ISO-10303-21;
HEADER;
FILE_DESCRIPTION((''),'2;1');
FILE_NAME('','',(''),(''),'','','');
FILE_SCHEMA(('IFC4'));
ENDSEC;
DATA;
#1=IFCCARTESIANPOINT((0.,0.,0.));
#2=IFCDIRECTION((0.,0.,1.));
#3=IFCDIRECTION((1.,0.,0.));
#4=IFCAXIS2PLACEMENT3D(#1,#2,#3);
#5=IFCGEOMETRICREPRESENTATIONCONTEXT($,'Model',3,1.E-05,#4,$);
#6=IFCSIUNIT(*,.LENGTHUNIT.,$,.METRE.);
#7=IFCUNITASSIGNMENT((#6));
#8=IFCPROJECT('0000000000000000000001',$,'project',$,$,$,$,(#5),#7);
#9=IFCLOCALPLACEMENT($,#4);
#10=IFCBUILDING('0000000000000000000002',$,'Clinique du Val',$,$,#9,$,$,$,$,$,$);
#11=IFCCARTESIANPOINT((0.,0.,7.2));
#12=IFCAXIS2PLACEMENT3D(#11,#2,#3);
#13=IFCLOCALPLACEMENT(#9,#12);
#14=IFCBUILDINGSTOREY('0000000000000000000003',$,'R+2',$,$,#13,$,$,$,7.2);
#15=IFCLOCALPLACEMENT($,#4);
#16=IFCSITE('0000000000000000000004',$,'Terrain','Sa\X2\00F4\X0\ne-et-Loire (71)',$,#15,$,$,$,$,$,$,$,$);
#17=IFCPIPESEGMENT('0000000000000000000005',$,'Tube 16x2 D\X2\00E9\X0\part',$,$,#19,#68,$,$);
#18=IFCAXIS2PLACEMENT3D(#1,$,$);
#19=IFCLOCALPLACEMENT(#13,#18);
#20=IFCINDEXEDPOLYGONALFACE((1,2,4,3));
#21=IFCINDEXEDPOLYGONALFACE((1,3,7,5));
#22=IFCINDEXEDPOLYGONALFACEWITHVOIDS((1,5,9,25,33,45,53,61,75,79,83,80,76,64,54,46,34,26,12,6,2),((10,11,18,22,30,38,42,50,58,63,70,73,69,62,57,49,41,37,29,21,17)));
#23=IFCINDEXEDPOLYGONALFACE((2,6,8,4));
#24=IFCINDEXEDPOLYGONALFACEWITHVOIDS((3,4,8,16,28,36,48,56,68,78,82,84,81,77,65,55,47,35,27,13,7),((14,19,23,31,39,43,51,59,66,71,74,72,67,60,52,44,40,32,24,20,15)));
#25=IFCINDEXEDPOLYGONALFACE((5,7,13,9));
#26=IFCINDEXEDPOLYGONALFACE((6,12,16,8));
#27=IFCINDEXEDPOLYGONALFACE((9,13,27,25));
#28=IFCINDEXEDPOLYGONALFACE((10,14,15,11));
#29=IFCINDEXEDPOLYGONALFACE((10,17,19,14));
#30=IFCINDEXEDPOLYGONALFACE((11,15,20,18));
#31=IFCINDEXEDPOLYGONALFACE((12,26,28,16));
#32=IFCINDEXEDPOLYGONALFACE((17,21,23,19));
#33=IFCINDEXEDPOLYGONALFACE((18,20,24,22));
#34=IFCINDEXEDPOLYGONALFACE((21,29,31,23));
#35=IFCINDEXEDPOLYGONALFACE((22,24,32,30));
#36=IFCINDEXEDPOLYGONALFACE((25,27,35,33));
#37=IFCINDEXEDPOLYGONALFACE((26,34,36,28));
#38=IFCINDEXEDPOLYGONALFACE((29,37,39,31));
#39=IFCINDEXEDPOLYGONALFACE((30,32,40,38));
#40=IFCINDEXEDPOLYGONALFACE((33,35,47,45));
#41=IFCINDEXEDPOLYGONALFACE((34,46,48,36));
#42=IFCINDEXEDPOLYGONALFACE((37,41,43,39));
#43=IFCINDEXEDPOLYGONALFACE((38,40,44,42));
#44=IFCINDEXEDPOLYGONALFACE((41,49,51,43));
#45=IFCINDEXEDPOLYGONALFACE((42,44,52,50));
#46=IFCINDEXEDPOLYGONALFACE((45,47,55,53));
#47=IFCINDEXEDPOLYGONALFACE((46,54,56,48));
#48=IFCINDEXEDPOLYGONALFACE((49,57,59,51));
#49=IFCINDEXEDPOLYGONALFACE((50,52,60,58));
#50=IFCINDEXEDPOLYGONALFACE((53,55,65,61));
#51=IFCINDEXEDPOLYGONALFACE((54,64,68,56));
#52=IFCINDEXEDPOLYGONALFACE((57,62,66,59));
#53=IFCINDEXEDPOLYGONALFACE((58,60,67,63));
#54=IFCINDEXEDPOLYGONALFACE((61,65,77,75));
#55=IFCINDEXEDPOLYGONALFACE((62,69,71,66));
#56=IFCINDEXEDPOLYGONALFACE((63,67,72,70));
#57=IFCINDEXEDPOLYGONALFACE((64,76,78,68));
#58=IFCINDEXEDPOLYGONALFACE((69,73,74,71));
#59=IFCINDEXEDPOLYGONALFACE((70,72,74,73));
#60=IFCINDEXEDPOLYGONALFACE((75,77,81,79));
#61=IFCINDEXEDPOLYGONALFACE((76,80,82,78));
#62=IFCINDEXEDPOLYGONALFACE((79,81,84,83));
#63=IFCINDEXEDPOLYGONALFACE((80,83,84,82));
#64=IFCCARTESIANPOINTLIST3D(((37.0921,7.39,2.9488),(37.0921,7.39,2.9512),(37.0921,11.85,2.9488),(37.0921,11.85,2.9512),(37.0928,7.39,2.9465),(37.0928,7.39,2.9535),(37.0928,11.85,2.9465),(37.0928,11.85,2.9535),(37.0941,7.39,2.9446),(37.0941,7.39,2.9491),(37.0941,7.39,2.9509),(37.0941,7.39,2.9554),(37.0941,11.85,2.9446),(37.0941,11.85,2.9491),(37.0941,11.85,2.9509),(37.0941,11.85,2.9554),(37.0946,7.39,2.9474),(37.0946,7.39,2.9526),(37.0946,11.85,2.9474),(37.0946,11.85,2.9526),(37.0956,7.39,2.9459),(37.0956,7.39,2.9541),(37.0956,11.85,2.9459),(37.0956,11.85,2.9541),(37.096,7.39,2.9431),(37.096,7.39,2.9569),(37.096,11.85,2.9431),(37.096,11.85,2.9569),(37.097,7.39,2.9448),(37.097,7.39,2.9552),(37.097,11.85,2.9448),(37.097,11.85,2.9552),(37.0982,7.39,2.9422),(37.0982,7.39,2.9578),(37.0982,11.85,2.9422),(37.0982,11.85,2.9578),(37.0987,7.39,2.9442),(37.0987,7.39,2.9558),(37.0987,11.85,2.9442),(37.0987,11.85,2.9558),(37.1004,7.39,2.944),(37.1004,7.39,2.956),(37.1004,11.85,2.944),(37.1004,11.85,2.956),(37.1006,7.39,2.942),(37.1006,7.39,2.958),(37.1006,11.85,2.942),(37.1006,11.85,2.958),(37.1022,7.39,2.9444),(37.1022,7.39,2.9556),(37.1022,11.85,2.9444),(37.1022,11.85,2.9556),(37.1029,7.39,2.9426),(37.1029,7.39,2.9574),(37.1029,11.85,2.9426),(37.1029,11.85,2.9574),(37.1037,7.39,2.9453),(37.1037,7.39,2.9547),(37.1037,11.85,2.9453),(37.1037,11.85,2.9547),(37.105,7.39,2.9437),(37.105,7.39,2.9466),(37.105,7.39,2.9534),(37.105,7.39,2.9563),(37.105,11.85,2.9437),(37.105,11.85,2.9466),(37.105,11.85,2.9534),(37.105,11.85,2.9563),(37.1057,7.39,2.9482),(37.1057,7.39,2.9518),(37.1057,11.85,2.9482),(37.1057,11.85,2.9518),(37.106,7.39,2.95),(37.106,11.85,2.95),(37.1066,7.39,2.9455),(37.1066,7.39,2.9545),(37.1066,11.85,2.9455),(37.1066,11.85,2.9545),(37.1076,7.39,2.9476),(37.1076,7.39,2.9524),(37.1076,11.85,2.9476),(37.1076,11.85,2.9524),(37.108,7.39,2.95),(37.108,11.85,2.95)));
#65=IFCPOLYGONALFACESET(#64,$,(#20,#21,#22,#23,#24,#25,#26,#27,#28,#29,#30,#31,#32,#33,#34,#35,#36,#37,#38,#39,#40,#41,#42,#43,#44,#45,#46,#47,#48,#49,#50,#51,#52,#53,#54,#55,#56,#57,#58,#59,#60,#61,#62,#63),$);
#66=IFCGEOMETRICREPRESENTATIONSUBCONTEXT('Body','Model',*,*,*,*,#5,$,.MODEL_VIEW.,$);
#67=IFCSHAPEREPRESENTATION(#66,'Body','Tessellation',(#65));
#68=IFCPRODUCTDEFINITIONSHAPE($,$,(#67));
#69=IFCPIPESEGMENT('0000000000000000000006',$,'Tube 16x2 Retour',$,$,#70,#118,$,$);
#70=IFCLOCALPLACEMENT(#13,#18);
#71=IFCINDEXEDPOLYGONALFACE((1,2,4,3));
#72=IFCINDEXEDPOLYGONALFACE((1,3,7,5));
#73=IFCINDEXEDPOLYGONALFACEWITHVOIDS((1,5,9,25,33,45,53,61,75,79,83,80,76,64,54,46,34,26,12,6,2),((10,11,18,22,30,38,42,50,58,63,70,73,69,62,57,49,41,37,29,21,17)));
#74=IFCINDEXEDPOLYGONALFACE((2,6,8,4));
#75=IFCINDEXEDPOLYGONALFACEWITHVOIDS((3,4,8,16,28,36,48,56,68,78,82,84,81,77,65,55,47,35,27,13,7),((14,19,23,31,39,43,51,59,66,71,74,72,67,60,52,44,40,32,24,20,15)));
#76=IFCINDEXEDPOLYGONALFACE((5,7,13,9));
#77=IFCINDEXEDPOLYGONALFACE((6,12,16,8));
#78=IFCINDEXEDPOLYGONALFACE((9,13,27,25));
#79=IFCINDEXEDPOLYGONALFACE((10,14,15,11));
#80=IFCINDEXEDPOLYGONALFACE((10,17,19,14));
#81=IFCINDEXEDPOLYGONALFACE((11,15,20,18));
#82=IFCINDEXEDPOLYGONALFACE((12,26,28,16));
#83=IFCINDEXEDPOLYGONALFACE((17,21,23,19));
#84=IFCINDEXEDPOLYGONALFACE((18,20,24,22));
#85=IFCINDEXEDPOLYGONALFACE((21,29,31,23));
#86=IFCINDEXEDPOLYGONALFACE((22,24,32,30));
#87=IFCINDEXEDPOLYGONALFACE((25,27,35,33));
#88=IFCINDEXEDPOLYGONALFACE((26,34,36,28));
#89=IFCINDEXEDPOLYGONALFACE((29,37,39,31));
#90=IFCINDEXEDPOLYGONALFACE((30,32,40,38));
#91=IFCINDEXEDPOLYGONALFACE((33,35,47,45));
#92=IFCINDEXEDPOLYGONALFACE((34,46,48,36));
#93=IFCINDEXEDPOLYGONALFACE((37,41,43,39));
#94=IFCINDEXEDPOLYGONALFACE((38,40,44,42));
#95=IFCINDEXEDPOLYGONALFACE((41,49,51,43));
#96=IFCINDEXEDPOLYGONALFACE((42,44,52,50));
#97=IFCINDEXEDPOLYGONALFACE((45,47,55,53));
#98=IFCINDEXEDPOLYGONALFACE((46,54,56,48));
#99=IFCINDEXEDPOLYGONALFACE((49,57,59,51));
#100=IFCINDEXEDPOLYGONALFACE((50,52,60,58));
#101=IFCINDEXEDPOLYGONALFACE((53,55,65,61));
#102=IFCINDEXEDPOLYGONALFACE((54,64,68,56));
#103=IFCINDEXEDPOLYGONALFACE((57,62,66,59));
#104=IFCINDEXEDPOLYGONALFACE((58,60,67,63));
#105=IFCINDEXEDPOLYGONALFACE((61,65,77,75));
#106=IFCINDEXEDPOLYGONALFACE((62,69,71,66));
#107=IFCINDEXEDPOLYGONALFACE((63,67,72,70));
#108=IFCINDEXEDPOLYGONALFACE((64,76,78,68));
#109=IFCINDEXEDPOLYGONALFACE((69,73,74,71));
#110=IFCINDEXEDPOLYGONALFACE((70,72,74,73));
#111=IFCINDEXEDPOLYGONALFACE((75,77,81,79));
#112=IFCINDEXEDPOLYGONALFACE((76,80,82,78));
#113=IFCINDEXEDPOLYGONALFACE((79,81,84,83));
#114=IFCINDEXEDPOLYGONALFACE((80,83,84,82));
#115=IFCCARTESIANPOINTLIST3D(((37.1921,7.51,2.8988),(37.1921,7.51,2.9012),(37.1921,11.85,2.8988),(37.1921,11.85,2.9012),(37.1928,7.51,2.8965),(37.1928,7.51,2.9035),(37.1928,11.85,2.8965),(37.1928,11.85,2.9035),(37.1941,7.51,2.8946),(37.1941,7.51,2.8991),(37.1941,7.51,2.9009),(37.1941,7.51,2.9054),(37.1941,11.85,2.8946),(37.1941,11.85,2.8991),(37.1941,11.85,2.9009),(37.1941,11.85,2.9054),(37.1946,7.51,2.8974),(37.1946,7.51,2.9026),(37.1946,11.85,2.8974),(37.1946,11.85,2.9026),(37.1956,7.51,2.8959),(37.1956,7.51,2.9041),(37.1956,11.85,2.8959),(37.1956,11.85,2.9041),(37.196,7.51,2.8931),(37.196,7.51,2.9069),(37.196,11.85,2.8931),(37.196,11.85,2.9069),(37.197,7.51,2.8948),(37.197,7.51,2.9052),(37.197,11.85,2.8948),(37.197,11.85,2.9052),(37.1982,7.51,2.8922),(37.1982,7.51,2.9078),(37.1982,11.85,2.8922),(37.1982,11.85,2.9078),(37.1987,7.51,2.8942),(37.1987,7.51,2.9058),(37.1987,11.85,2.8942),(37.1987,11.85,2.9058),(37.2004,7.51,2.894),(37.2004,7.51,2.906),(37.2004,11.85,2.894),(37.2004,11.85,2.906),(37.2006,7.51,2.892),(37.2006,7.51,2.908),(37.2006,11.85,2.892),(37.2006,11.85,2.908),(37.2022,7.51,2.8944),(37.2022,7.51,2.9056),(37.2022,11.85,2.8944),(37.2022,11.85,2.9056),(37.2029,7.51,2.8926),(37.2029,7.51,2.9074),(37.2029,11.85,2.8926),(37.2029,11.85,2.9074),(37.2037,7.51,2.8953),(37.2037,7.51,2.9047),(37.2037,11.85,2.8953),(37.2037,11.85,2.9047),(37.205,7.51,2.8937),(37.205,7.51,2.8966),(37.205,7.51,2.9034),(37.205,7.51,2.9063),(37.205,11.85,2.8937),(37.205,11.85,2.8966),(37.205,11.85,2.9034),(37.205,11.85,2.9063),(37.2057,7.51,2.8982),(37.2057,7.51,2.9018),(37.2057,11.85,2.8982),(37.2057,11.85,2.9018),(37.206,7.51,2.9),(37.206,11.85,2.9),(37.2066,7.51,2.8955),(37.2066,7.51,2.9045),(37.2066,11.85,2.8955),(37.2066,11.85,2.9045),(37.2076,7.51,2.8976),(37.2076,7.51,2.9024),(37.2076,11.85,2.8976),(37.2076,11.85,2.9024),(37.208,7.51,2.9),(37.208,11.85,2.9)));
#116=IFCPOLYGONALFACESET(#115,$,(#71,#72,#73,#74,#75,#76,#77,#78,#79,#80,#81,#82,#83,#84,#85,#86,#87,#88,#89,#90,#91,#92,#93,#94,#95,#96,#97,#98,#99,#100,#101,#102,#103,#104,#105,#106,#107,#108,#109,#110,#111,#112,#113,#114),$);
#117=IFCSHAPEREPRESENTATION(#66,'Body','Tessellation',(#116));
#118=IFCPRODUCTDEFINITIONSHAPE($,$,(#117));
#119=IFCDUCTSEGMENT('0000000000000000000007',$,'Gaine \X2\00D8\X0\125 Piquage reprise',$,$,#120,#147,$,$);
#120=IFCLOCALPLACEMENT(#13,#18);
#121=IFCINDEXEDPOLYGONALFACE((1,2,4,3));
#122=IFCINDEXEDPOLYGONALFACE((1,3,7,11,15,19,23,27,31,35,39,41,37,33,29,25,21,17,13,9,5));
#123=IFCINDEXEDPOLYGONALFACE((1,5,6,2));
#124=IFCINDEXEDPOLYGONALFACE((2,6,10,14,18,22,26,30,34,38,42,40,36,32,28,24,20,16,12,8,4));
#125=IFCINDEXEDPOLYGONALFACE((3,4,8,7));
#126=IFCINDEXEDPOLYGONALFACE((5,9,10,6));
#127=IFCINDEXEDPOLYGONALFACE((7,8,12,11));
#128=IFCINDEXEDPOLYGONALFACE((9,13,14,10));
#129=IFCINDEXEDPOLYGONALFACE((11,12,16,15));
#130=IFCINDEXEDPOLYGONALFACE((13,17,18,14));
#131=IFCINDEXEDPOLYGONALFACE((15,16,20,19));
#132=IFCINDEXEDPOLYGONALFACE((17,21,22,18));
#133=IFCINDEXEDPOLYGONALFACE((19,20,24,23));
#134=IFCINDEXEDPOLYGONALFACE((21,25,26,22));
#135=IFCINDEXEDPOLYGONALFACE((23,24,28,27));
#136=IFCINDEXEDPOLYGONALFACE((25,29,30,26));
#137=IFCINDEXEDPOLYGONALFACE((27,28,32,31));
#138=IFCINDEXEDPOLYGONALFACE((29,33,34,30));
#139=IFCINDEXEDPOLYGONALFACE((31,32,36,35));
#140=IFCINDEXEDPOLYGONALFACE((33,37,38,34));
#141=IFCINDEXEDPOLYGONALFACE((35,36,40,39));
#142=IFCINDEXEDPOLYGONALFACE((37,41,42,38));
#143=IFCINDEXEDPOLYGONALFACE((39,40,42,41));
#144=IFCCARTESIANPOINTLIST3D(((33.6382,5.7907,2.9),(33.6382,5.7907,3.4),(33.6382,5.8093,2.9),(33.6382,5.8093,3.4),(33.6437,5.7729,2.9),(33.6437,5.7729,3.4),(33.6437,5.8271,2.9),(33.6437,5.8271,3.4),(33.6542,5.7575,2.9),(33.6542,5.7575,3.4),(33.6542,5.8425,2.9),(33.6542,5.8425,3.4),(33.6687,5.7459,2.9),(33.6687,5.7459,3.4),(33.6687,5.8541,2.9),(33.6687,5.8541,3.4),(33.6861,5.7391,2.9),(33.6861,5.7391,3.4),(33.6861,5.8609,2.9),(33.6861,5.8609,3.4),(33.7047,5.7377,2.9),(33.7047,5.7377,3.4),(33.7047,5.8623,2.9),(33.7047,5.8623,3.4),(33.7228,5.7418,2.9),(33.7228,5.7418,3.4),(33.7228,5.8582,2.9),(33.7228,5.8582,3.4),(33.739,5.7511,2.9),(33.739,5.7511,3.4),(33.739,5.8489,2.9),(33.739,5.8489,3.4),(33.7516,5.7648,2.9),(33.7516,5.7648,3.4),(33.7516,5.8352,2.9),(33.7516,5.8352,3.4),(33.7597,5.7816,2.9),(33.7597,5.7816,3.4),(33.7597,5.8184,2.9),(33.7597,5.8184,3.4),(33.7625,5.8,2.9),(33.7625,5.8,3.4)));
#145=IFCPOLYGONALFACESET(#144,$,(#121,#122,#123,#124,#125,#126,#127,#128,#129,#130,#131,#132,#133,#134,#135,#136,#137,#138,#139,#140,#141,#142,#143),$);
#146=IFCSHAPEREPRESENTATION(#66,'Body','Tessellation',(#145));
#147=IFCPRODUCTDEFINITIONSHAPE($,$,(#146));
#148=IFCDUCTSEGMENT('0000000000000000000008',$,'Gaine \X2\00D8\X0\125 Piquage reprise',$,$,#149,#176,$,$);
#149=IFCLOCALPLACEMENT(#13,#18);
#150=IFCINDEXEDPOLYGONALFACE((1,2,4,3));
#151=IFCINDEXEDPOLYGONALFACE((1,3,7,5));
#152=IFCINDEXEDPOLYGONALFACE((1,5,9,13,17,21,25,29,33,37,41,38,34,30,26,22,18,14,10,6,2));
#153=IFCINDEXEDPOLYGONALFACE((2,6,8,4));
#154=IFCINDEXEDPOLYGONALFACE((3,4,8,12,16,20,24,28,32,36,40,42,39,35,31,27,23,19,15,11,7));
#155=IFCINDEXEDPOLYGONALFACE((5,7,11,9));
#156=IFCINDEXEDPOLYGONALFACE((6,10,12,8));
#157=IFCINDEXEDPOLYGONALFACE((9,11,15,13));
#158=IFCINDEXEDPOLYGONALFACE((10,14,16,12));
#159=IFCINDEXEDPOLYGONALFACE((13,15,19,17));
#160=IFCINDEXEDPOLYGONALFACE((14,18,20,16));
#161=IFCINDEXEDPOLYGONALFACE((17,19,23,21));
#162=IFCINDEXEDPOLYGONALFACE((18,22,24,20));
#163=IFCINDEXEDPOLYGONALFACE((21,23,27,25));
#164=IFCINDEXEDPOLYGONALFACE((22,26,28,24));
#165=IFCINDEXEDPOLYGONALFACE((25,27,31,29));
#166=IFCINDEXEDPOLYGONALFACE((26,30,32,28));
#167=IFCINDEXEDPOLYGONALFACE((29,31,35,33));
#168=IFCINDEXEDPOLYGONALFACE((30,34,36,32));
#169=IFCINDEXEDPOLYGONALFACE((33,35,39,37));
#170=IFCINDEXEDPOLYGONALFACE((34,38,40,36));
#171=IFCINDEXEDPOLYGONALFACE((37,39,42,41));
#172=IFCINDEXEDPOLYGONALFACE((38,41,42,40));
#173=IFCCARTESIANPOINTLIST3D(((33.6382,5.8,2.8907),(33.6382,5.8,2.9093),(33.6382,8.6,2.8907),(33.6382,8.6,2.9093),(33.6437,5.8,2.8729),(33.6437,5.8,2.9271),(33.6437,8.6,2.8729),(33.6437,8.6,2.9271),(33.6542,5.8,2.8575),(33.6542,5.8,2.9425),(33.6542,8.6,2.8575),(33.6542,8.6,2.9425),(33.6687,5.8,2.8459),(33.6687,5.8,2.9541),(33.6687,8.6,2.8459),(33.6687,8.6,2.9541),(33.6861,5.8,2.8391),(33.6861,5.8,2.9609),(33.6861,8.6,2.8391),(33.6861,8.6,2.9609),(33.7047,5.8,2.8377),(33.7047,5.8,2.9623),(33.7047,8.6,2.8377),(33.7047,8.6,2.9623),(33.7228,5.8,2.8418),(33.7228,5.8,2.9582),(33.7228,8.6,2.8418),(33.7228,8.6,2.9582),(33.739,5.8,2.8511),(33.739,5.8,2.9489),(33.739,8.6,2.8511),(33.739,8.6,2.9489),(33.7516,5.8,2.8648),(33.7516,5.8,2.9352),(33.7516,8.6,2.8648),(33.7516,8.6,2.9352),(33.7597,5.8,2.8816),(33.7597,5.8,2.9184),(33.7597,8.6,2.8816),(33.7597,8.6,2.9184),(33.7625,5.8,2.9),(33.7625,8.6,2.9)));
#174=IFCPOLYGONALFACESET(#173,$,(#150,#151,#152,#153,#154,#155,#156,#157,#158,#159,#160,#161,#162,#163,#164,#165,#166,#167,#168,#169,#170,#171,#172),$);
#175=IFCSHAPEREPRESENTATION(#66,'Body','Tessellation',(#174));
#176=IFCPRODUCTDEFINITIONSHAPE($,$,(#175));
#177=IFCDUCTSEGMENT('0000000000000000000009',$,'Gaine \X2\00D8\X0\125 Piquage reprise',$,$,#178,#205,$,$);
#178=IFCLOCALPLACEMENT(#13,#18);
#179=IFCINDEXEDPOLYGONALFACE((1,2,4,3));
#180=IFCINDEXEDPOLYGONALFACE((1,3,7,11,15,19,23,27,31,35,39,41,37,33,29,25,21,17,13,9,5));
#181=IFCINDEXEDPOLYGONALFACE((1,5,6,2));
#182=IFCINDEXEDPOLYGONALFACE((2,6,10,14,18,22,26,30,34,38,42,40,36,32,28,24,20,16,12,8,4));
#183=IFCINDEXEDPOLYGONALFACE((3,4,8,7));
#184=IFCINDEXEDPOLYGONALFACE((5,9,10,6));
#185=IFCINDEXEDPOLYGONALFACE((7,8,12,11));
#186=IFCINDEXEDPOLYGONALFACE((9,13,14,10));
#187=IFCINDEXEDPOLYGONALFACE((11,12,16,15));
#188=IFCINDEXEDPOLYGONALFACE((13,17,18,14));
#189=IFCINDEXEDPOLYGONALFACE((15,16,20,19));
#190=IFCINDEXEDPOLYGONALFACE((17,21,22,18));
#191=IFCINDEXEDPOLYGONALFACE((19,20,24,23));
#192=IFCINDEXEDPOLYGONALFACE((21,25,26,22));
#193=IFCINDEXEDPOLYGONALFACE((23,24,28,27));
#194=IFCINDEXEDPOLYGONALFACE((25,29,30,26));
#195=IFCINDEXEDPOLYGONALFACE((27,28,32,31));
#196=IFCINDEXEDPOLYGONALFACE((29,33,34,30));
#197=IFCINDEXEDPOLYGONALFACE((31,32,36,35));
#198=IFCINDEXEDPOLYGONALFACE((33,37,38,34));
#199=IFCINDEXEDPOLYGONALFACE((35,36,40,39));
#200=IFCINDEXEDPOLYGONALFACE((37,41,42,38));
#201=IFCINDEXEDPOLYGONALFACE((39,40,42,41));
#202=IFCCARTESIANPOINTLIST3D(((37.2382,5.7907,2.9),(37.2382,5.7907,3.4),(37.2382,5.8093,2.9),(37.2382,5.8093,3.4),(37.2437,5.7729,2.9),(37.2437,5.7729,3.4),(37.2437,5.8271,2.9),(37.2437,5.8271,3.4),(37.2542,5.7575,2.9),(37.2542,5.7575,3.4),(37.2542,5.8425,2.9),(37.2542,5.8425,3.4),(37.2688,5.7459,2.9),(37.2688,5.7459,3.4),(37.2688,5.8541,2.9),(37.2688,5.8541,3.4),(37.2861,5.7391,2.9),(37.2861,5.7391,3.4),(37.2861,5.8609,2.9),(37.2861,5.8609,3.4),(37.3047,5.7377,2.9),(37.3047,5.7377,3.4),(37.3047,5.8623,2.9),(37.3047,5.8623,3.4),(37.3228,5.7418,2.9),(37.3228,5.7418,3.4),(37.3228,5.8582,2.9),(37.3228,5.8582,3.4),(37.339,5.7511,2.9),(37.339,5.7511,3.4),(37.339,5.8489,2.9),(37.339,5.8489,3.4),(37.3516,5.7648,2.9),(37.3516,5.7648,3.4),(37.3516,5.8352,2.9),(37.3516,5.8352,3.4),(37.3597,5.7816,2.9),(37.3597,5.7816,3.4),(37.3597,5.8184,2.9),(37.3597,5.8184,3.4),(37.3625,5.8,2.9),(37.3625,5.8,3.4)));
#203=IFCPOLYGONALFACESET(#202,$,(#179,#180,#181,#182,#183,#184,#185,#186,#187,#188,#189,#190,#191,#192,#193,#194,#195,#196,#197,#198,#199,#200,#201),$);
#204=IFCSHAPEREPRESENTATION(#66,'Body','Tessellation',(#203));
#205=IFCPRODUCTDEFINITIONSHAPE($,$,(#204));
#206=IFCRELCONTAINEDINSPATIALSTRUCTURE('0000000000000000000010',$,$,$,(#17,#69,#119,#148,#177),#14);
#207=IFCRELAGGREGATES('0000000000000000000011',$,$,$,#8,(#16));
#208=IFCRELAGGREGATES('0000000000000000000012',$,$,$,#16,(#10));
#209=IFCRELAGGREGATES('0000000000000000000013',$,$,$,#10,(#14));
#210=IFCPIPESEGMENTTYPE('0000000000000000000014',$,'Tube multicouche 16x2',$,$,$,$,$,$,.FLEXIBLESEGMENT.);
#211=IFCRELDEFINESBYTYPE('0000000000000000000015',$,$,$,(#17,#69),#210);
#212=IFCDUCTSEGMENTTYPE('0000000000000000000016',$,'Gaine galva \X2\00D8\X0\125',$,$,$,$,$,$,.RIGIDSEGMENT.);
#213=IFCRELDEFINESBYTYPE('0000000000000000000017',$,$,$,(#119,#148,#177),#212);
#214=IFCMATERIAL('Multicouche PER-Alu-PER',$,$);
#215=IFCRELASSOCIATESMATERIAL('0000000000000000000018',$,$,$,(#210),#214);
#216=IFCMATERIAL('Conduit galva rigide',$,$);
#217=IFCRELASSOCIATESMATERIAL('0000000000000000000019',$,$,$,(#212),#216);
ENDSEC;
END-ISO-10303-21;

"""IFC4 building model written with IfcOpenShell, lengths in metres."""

from ifc_helpers import new_model, si_unit, frame, origin_with_axes, place, context, subcontext, project, spatial, circle, hollow_circle, extrude, material, type_object, element, save


model = new_model("IFC4")

# Units and contexts
model_context = context("Model", 3, precision=1e-05, world=origin_with_axes())
body_context = subcontext(model_context, "Body", "Model", "MODEL_VIEW")
ifc_project = project(units=[si_unit("LENGTHUNIT", "METRE")], contexts=[model_context])

# Site, building, storey
site_placement = place(None, origin_with_axes())
site = spatial("IfcSite", under=ifc_project, at=site_placement, Name="Terrain", Description="Saône-et-Loire (71)")
building_placement = place(None, origin_with_axes())
building = spatial("IfcBuilding", under=site, at=building_placement, Name="Clinique du Val")
storey_placement = place(building_placement, frame((0.0, 0.0, 7.2), z_axis=(0.0, 0.0, 1.0), x_axis=(1.0, 0.0, 0.0)))
storey = spatial("IfcBuildingStorey", under=building, at=storey_placement, Name="R+2", Elevation=7.2)

# Pipe segments
ifc_material_1 = material(Name="Multicouche PER-Alu-PER")
pipe_segment_type_1 = type_object("IfcPipeSegmentType", Name="Tube multicouche 16x2", PredefinedType="FLEXIBLESEGMENT", material=ifc_material_1)
pipe_segment_1_placement = place(storey_placement, frame((37.1, 7.39, 2.95), z_axis=(0.0, 1.0, 0.0), x_axis=(1.0, 0.0, 0.0)))
element("IfcPipeSegment", 1, at=pipe_segment_1_placement, inside=storey, type_object=pipe_segment_type_1, Name="Tube 16x2 Départ", context=body_context, shape_type="SweptSolid", body=[
    extrude(hollow_circle(Radius=0.008, WallThickness=0.002), origin_with_axes(), (0.0, 0.0, 1.0), 4.46),
])
pipe_segment_2_placement = place(storey_placement, frame((37.2, 7.51, 2.9), z_axis=(0.0, 1.0, 0.0), x_axis=(1.0, 0.0, 0.0)))
element("IfcPipeSegment", 2, at=pipe_segment_2_placement, inside=storey, type_object=pipe_segment_type_1, Name="Tube 16x2 Retour", context=body_context, shape_type="SweptSolid", body=[
    extrude(hollow_circle(Radius=0.008, WallThickness=0.002), origin_with_axes(), (0.0, 0.0, 1.0), 4.34),
])

# Duct segments
ifc_material_2 = material(Name="Conduit galva rigide")
duct_segment_type = type_object("IfcDuctSegmentType", Name="Gaine galva Ø125", PredefinedType="RIGIDSEGMENT", material=ifc_material_2)
duct_segment_1_placement = place(storey_placement, frame((33.7, 5.8, 3.4), z_axis=(0.0, 0.0, -1.0), x_axis=(1.0, 0.0, 0.0)))
element("IfcDuctSegment", 3, at=duct_segment_1_placement, inside=storey, type_object=duct_segment_type, Name="Gaine Ø125 Piquage reprise", context=body_context, shape_type="SweptSolid", body=[
    extrude(circle(Radius=0.0625), origin_with_axes(), (0.0, 0.0, 1.0), 0.5),
])
duct_segment_2_placement = place(storey_placement, frame((33.7, 5.8, 2.9), z_axis=(0.0, 1.0, 0.0), x_axis=(1.0, 0.0, 0.0)))
element("IfcDuctSegment", 4, at=duct_segment_2_placement, inside=storey, type_object=duct_segment_type, Name="Gaine Ø125 Piquage reprise", context=body_context, shape_type="SweptSolid", body=[
    extrude(circle(Radius=0.0625), origin_with_axes(), (0.0, 0.0, 1.0), 2.8),
])
duct_segment_3_placement = place(storey_placement, frame((37.3, 5.8, 3.4), z_axis=(0.0, 0.0, -1.0), x_axis=(1.0, 0.0, 0.0)))
element("IfcDuctSegment", 5, at=duct_segment_3_placement, inside=storey, type_object=duct_segment_type, Name="Gaine Ø125 Piquage reprise", context=body_context, shape_type="SweptSolid", body=[
    extrude(circle(Radius=0.0625), origin_with_axes(), (0.0, 0.0, 1.0), 0.5),
])

save(model, "model.ifc")
